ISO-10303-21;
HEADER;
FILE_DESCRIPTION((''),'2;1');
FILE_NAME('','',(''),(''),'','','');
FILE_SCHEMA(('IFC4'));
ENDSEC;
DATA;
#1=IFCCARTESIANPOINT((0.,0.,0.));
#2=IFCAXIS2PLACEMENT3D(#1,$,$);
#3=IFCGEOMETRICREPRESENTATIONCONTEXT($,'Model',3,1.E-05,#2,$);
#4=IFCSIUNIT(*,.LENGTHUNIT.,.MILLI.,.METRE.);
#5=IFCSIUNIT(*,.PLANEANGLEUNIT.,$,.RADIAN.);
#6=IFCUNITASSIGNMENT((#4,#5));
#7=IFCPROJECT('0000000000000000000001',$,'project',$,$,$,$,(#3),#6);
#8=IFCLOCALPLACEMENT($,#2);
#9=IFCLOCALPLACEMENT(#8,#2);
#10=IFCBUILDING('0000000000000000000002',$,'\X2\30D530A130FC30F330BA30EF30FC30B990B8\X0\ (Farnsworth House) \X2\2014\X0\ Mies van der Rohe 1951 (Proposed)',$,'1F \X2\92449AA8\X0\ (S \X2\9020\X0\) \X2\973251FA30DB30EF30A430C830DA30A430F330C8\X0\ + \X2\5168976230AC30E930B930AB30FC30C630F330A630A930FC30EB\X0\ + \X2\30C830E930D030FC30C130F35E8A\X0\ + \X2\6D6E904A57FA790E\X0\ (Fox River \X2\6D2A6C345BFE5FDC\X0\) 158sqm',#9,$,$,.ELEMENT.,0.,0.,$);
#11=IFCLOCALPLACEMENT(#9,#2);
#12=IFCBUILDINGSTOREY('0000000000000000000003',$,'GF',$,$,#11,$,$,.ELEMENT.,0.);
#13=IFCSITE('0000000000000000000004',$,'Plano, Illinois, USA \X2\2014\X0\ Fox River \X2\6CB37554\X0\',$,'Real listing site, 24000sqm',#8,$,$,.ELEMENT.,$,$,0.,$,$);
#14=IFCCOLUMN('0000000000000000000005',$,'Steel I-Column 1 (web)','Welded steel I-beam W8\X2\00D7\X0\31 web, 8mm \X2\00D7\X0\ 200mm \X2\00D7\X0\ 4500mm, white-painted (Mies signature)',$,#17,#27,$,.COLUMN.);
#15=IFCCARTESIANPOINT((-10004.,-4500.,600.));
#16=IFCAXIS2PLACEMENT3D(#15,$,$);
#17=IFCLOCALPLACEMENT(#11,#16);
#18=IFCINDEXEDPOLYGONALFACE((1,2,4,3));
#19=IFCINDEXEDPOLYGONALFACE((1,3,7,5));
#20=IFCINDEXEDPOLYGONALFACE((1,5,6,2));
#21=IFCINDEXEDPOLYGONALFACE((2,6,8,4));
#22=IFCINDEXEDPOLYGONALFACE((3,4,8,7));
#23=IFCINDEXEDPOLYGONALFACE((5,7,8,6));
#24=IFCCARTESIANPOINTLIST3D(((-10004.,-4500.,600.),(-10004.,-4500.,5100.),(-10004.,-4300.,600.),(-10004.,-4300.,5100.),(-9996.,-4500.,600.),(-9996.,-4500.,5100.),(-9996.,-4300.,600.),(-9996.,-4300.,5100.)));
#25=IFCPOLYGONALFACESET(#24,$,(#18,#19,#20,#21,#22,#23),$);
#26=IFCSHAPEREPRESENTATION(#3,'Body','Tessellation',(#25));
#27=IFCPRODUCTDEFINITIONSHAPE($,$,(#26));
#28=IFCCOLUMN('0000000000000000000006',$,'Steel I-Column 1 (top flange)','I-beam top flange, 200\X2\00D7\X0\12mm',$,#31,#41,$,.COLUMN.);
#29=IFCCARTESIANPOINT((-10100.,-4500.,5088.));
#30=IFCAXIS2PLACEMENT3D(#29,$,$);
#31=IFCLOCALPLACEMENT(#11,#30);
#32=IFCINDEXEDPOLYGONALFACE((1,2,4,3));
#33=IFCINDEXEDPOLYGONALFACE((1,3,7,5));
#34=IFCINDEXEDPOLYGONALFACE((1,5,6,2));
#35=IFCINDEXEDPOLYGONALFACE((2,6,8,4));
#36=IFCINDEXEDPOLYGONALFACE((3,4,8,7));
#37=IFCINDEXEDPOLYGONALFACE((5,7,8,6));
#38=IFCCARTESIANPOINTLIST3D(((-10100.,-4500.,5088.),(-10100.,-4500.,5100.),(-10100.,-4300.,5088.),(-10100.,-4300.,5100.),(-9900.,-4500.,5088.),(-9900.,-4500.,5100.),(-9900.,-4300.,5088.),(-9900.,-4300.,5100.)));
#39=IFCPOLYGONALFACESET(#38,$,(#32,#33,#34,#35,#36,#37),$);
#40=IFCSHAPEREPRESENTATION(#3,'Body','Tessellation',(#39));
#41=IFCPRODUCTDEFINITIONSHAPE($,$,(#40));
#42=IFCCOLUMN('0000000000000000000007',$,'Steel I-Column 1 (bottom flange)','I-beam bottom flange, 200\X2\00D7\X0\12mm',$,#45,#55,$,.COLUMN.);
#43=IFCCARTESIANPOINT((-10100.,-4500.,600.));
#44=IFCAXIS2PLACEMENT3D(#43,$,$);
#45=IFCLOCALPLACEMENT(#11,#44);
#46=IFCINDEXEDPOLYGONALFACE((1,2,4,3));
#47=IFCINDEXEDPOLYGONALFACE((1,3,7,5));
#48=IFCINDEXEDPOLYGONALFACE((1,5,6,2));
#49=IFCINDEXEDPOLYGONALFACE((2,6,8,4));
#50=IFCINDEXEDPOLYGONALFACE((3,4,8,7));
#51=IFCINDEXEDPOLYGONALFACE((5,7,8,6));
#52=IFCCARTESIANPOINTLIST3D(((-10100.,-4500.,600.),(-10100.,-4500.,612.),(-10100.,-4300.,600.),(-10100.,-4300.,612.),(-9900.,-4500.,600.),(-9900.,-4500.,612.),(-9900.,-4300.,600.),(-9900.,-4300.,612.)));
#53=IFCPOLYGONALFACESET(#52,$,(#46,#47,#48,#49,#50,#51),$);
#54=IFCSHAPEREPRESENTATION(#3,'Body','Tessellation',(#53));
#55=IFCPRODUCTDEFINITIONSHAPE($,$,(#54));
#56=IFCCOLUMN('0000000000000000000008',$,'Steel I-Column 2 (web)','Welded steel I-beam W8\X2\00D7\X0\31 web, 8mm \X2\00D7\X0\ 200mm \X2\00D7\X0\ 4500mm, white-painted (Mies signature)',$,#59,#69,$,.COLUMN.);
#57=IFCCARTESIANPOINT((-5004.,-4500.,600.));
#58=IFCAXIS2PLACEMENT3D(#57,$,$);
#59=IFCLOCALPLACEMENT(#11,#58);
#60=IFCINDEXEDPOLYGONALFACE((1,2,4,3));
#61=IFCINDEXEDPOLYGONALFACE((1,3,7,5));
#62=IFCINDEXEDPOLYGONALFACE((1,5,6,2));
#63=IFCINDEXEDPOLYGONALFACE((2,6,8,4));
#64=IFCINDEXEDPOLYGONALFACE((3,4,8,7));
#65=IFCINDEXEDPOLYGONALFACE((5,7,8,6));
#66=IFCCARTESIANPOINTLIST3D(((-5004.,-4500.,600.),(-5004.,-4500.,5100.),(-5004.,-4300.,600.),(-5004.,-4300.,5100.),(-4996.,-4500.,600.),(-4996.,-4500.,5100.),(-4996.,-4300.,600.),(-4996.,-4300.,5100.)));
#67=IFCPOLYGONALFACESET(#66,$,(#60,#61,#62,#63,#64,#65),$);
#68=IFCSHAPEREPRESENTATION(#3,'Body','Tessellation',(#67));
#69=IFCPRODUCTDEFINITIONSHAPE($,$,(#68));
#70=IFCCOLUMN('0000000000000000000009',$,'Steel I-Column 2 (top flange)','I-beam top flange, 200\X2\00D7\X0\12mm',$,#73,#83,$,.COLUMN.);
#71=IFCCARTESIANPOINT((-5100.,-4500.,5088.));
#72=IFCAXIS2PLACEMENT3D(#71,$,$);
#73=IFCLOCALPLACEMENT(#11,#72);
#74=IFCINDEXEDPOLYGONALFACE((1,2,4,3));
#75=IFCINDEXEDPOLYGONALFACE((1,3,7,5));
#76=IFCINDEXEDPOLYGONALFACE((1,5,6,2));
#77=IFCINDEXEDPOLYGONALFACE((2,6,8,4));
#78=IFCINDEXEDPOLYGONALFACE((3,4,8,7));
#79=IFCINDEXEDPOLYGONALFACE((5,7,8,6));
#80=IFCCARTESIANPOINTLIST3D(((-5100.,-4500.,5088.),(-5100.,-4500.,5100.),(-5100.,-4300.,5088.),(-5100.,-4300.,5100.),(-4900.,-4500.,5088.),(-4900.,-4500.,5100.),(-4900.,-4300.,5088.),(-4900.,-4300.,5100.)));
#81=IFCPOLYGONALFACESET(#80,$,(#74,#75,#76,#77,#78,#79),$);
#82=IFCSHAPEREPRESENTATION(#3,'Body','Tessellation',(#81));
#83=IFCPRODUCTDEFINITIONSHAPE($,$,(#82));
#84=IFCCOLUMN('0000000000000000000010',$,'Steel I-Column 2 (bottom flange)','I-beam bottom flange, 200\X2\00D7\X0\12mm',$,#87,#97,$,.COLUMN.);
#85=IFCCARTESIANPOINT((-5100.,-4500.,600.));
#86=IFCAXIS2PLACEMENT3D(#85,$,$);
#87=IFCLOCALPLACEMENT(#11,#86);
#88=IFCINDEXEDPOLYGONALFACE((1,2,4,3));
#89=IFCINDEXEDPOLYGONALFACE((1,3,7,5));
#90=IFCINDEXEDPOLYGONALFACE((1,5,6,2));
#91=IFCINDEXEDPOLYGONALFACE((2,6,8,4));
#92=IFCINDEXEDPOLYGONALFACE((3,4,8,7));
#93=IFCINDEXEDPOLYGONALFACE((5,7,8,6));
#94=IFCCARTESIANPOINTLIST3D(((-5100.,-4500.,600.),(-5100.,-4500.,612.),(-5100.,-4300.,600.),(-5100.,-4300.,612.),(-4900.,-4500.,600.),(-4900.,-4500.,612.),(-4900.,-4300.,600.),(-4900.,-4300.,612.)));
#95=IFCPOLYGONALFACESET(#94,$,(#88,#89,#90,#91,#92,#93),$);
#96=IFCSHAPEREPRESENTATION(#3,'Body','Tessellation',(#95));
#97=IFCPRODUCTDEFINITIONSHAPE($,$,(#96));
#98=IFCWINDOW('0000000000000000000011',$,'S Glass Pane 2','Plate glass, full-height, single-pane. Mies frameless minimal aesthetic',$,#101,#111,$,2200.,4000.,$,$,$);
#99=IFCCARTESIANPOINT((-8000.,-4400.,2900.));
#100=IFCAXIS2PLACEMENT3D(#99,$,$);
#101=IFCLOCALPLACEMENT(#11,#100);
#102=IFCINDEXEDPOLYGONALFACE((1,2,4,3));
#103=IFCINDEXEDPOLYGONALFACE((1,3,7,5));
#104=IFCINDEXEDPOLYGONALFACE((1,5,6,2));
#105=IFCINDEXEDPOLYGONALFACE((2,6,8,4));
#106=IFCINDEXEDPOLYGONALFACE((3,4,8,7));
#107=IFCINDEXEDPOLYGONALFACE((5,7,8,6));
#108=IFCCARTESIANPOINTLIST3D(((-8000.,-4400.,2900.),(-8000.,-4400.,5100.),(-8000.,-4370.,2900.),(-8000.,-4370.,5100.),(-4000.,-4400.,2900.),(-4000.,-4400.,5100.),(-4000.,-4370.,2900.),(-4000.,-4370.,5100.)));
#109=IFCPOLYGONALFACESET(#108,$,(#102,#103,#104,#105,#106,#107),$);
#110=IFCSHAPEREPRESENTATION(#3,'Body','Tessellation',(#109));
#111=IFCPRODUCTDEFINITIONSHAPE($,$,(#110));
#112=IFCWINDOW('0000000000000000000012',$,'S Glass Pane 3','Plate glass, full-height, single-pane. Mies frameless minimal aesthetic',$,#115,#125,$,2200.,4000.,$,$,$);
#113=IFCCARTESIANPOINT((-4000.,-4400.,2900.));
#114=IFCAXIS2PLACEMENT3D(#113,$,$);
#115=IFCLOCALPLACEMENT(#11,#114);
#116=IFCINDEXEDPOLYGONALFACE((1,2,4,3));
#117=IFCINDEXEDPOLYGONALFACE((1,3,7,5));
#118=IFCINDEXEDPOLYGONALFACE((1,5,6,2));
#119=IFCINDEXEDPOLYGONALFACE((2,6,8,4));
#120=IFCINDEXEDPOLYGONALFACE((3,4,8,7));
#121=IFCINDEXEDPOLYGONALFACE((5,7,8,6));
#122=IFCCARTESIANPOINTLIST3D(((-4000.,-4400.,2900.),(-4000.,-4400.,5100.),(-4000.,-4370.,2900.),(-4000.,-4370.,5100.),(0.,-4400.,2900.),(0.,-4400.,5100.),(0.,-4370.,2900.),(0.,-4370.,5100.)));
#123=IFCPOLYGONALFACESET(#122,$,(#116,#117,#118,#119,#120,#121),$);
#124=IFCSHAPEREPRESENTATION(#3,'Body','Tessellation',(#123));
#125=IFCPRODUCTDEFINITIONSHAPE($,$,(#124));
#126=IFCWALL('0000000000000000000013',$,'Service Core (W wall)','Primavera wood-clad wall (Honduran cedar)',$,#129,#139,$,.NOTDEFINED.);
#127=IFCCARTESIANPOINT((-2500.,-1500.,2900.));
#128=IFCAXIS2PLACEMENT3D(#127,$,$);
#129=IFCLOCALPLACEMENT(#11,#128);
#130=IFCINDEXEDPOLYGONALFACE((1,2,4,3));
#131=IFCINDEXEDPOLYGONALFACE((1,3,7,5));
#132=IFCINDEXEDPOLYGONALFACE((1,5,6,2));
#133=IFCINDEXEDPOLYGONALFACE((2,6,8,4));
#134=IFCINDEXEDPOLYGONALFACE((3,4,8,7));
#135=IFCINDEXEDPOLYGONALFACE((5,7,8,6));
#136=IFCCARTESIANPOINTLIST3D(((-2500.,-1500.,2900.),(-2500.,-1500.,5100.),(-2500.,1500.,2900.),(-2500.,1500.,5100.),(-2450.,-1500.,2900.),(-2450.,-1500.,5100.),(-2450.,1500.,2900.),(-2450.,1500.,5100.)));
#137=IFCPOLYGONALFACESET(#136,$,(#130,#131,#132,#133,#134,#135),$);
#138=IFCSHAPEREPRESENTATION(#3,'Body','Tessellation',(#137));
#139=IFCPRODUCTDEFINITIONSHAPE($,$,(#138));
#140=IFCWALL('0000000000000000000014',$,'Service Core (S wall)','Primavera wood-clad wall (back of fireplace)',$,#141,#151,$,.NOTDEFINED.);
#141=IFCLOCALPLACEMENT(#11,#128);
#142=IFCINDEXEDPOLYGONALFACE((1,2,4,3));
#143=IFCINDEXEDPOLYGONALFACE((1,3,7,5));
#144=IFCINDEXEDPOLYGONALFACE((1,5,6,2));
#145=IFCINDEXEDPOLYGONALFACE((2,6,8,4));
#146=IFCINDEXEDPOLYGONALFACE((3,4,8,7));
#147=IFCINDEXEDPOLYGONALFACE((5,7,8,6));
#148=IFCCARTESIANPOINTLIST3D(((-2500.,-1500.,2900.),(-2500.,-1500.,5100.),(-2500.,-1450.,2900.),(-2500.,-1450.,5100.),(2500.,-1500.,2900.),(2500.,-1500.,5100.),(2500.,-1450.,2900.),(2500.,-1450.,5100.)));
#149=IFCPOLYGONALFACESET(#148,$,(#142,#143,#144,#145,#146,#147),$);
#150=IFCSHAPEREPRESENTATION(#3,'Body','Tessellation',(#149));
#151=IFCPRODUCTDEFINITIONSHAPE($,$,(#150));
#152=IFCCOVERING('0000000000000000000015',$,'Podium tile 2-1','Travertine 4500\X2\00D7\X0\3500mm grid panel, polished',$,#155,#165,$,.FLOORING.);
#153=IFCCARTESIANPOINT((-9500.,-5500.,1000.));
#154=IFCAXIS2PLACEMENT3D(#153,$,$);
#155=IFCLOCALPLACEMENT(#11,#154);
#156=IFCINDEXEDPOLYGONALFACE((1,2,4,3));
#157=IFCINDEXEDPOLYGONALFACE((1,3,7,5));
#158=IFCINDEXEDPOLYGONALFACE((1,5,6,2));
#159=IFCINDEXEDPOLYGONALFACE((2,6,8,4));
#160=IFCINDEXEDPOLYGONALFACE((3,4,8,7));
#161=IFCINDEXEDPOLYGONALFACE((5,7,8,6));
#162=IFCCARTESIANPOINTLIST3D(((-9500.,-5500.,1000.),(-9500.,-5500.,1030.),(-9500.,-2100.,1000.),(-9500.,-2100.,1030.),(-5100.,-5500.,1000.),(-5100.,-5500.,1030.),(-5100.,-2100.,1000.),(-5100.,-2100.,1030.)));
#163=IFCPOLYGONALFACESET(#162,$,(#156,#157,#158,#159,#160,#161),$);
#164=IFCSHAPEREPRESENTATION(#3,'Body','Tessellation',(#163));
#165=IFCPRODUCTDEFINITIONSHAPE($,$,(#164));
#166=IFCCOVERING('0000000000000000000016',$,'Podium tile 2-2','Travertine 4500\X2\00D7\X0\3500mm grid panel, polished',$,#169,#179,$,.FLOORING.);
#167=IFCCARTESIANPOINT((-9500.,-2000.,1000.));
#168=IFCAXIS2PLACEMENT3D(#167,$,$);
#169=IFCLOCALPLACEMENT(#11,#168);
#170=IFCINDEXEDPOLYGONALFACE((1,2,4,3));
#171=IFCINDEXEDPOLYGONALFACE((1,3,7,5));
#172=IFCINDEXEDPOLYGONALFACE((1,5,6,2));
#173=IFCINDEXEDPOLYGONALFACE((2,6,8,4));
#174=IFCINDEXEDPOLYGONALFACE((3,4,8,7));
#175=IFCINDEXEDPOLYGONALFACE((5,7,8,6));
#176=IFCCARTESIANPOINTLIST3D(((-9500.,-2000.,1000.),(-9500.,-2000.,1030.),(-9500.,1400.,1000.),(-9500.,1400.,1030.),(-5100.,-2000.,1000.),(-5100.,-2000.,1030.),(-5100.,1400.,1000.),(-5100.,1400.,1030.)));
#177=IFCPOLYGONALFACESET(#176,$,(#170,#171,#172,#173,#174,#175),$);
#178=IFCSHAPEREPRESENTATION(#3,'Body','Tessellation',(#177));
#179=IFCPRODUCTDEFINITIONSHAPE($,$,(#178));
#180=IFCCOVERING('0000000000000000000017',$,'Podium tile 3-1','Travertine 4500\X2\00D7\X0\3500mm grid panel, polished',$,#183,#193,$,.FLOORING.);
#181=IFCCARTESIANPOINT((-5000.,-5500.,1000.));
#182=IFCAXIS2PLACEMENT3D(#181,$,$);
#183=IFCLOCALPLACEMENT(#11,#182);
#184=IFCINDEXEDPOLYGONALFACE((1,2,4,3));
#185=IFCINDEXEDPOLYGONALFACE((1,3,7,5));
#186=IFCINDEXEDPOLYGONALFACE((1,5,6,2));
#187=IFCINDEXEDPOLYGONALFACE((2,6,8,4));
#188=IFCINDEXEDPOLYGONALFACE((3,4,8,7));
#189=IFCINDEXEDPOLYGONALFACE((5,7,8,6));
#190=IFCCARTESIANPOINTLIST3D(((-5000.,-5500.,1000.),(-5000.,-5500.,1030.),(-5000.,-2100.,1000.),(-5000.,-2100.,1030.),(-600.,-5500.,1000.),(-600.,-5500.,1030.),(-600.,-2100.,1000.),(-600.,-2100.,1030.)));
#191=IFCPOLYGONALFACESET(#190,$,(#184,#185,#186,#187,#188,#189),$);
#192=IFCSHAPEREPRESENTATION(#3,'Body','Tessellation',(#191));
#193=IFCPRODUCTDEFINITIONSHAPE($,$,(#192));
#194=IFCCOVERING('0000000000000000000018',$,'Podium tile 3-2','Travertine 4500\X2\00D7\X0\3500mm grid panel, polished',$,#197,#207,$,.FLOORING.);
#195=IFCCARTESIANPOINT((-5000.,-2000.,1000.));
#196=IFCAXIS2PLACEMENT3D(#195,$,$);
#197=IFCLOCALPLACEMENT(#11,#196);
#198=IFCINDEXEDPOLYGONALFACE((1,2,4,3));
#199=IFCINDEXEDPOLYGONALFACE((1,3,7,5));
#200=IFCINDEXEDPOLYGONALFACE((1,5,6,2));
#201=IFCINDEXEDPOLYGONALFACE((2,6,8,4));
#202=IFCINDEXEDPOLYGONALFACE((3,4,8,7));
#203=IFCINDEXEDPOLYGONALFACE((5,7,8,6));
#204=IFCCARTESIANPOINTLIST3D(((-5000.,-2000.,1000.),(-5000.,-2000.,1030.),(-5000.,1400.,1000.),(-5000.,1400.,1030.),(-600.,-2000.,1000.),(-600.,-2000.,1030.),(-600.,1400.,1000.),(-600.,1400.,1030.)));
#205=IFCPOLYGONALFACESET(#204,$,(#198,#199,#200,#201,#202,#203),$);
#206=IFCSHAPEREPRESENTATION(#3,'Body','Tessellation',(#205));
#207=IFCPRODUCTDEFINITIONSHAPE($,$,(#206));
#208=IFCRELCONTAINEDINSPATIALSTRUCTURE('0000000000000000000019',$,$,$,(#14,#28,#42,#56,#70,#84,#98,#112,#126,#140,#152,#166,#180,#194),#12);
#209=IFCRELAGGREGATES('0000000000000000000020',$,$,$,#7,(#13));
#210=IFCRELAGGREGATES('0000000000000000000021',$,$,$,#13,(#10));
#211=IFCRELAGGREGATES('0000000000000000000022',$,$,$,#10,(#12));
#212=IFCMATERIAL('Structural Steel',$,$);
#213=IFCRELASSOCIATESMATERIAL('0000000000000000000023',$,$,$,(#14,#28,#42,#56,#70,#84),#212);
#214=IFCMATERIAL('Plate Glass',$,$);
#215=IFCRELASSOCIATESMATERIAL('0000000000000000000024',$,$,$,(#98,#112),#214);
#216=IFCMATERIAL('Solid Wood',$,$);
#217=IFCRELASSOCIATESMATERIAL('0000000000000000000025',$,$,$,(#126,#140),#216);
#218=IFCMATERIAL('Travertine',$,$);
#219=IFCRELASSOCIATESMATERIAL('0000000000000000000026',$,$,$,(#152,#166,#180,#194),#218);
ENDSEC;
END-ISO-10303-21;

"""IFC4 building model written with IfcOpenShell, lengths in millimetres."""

from ifc_helpers import new_model, si_unit, frame, frame_2d, origin, place, context, project, spatial, rectangle, extrude, material, element, save


model = new_model("IFC4")

# Units and contexts
model_context = context("Model", 3, precision=1e-05, world=origin())
ifc_project = project(units=[si_unit("LENGTHUNIT", "METRE", prefix="MILLI"), si_unit("PLANEANGLEUNIT", "RADIAN")], contexts=[model_context])

# Site, building, storey
site_placement = place(None, origin())
site = spatial("IfcSite", under=ifc_project, at=site_placement, Name="Plano, Illinois, USA — Fox River 河畔", ObjectType="Real listing site, 24000sqm", CompositionType="ELEMENT", RefElevation=0.0)
building_placement = place(site_placement, origin())
building = spatial("IfcBuilding", under=site, at=building_placement, Name="ファーンズワース邸 (Farnsworth House) — Mies van der Rohe 1951 (Proposed)", ObjectType="1F 鉄骨 (S 造) 露出ホワイトペイント + 全面ガラスカーテンウォール + トラバーチン床 + 浮遊基礎 (Fox River 洪水対応) 158sqm", CompositionType="ELEMENT", ElevationOfRefHeight=0.0, ElevationOfTerrain=0.0)
storey_placement = place(building_placement, origin())
storey = spatial("IfcBuildingStorey", under=building, at=storey_placement, Name="GF", CompositionType="ELEMENT", Elevation=0.0)

# Columns
ifc_material_1 = material(Name="Structural Steel")
column_1_placement = place(storey_placement, frame((-10004.0, -4500.0, 600.0)))
element("IfcColumn", 1, at=column_1_placement, inside=storey, material=ifc_material_1, Name="Steel I-Column 1 (web)", Description="Welded steel I-beam W8×31 web, 8mm × 200mm × 4500mm, white-painted (Mies signature)", PredefinedType="COLUMN", context=model_context, shape_type="SweptSolid", body=[
    extrude(rectangle(XDim=8.0, YDim=200.0, at=frame_2d((4.0, 100.0))), frame((-10004.0, -4500.0, 600.0)), (0.0, 0.0, 1.0), 4500.0),
])
column_2_placement = place(storey_placement, frame((-10100.0, -4500.0, 5088.0)))
element("IfcColumn", 2, at=column_2_placement, inside=storey, material=ifc_material_1, Name="Steel I-Column 1 (top flange)", Description="I-beam top flange, 200×12mm", PredefinedType="COLUMN", context=model_context, shape_type="SweptSolid", body=[
    extrude(rectangle(XDim=200.0, YDim=200.0, at=frame_2d((100.0, 100.0))), frame((-10100.0, -4500.0, 5088.0)), (0.0, 0.0, 1.0), 12.0),
])
column_3_placement = place(storey_placement, frame((-10100.0, -4500.0, 600.0)))
element("IfcColumn", 3, at=column_3_placement, inside=storey, material=ifc_material_1, Name="Steel I-Column 1 (bottom flange)", Description="I-beam bottom flange, 200×12mm", PredefinedType="COLUMN", context=model_context, shape_type="SweptSolid", body=[
    extrude(rectangle(XDim=200.0, YDim=200.0, at=frame_2d((100.0, 100.0))), frame((-10100.0, -4500.0, 600.0)), (0.0, 0.0, 1.0), 12.0),
])
column_4_placement = place(storey_placement, frame((-5004.0, -4500.0, 600.0)))
element("IfcColumn", 4, at=column_4_placement, inside=storey, material=ifc_material_1, Name="Steel I-Column 2 (web)", Description="Welded steel I-beam W8×31 web, 8mm × 200mm × 4500mm, white-painted (Mies signature)", PredefinedType="COLUMN", context=model_context, shape_type="SweptSolid", body=[
    extrude(rectangle(XDim=8.0, YDim=200.0, at=frame_2d((4.0, 100.0))), frame((-5004.0, -4500.0, 600.0)), (0.0, 0.0, 1.0), 4500.0),
])
column_5_placement = place(storey_placement, frame((-5100.0, -4500.0, 5088.0)))
element("IfcColumn", 5, at=column_5_placement, inside=storey, material=ifc_material_1, Name="Steel I-Column 2 (top flange)", Description="I-beam top flange, 200×12mm", PredefinedType="COLUMN", context=model_context, shape_type="SweptSolid", body=[
    extrude(rectangle(XDim=200.0, YDim=200.0, at=frame_2d((100.0, 100.0))), frame((-5100.0, -4500.0, 5088.0)), (0.0, 0.0, 1.0), 12.0),
])
column_6_placement = place(storey_placement, frame((-5100.0, -4500.0, 600.0)))
element("IfcColumn", 6, at=column_6_placement, inside=storey, material=ifc_material_1, Name="Steel I-Column 2 (bottom flange)", Description="I-beam bottom flange, 200×12mm", PredefinedType="COLUMN", context=model_context, shape_type="SweptSolid", body=[
    extrude(rectangle(XDim=200.0, YDim=200.0, at=frame_2d((100.0, 100.0))), frame((-5100.0, -4500.0, 600.0)), (0.0, 0.0, 1.0), 12.0),
])

# Windows
ifc_material_2 = material(Name="Plate Glass")
window_1_placement = place(storey_placement, frame((-8000.0, -4400.0, 2900.0)))
element("IfcWindow", 7, at=window_1_placement, inside=storey, material=ifc_material_2, Name="S Glass Pane 2", Description="Plate glass, full-height, single-pane. Mies frameless minimal aesthetic", OverallHeight=2200.0, OverallWidth=4000.0, context=model_context, shape_type="SweptSolid", body=[
    extrude(rectangle(XDim=4000.0, YDim=30.0, at=frame_2d((2000.0, 15.0))), frame((-8000.0, -4400.0, 2900.0)), (0.0, 0.0, 1.0), 2200.0),
])
window_2_placement = place(storey_placement, frame((-4000.0, -4400.0, 2900.0)))
element("IfcWindow", 8, at=window_2_placement, inside=storey, material=ifc_material_2, Name="S Glass Pane 3", Description="Plate glass, full-height, single-pane. Mies frameless minimal aesthetic", OverallHeight=2200.0, OverallWidth=4000.0, context=model_context, shape_type="SweptSolid", body=[
    extrude(rectangle(XDim=4000.0, YDim=30.0, at=frame_2d((2000.0, 15.0))), frame((-4000.0, -4400.0, 2900.0)), (0.0, 0.0, 1.0), 2200.0),
])

# Walls
ifc_material_3 = material(Name="Solid Wood")
wall_1_placement = place(storey_placement, frame((-2500.0, -1500.0, 2900.0)))
element("IfcWall", 9, at=wall_1_placement, inside=storey, material=ifc_material_3, Name="Service Core (W wall)", Description="Primavera wood-clad wall (Honduran cedar)", PredefinedType="NOTDEFINED", context=model_context, shape_type="SweptSolid", body=[
    extrude(rectangle(XDim=50.0, YDim=3000.0, at=frame_2d((25.0, 1500.0))), frame((-2500.0, -1500.0, 2900.0)), (0.0, 0.0, 1.0), 2200.0),
])
wall_2_placement = place(storey_placement, frame((-2500.0, -1500.0, 2900.0)))
element("IfcWall", 10, at=wall_2_placement, inside=storey, material=ifc_material_3, Name="Service Core (S wall)", Description="Primavera wood-clad wall (back of fireplace)", PredefinedType="NOTDEFINED", context=model_context, shape_type="SweptSolid", body=[
    extrude(rectangle(XDim=5000.0, YDim=50.0, at=frame_2d((2500.0, 25.0))), frame((-2500.0, -1500.0, 2900.0)), (0.0, 0.0, 1.0), 2200.0),
])

# Coverings
ifc_material_4 = material(Name="Travertine")
covering_1_placement = place(storey_placement, frame((-9500.0, -5500.0, 1000.0)))
element("IfcCovering", 11, at=covering_1_placement, inside=storey, material=ifc_material_4, Name="Podium tile 2-1", Description="Travertine 4500×3500mm grid panel, polished", PredefinedType="FLOORING", context=model_context, shape_type="SweptSolid", body=[
    extrude(rectangle(XDim=4400.0, YDim=3400.0, at=frame_2d((2200.0, 1700.0))), frame((-9500.0, -5500.0, 1000.0)), (0.0, 0.0, 1.0), 30.0),
])
covering_2_placement = place(storey_placement, frame((-9500.0, -2000.0, 1000.0)))
element("IfcCovering", 12, at=covering_2_placement, inside=storey, material=ifc_material_4, Name="Podium tile 2-2", Description="Travertine 4500×3500mm grid panel, polished", PredefinedType="FLOORING", context=model_context, shape_type="SweptSolid", body=[
    extrude(rectangle(XDim=4400.0, YDim=3400.0, at=frame_2d((2200.0, 1700.0))), frame((-9500.0, -2000.0, 1000.0)), (0.0, 0.0, 1.0), 30.0),
])
covering_3_placement = place(storey_placement, frame((-5000.0, -5500.0, 1000.0)))
element("IfcCovering", 13, at=covering_3_placement, inside=storey, material=ifc_material_4, Name="Podium tile 3-1", Description="Travertine 4500×3500mm grid panel, polished", PredefinedType="FLOORING", context=model_context, shape_type="SweptSolid", body=[
    extrude(rectangle(XDim=4400.0, YDim=3400.0, at=frame_2d((2200.0, 1700.0))), frame((-5000.0, -5500.0, 1000.0)), (0.0, 0.0, 1.0), 30.0),
])
covering_4_placement = place(storey_placement, frame((-5000.0, -2000.0, 1000.0)))
element("IfcCovering", 14, at=covering_4_placement, inside=storey, material=ifc_material_4, Name="Podium tile 3-2", Description="Travertine 4500×3500mm grid panel, polished", PredefinedType="FLOORING", context=model_context, shape_type="SweptSolid", body=[
    extrude(rectangle(XDim=4400.0, YDim=3400.0, at=frame_2d((2200.0, 1700.0))), frame((-5000.0, -2000.0, 1000.0)), (0.0, 0.0, 1.0), 30.0),
])

save(model, "model.ifc")
